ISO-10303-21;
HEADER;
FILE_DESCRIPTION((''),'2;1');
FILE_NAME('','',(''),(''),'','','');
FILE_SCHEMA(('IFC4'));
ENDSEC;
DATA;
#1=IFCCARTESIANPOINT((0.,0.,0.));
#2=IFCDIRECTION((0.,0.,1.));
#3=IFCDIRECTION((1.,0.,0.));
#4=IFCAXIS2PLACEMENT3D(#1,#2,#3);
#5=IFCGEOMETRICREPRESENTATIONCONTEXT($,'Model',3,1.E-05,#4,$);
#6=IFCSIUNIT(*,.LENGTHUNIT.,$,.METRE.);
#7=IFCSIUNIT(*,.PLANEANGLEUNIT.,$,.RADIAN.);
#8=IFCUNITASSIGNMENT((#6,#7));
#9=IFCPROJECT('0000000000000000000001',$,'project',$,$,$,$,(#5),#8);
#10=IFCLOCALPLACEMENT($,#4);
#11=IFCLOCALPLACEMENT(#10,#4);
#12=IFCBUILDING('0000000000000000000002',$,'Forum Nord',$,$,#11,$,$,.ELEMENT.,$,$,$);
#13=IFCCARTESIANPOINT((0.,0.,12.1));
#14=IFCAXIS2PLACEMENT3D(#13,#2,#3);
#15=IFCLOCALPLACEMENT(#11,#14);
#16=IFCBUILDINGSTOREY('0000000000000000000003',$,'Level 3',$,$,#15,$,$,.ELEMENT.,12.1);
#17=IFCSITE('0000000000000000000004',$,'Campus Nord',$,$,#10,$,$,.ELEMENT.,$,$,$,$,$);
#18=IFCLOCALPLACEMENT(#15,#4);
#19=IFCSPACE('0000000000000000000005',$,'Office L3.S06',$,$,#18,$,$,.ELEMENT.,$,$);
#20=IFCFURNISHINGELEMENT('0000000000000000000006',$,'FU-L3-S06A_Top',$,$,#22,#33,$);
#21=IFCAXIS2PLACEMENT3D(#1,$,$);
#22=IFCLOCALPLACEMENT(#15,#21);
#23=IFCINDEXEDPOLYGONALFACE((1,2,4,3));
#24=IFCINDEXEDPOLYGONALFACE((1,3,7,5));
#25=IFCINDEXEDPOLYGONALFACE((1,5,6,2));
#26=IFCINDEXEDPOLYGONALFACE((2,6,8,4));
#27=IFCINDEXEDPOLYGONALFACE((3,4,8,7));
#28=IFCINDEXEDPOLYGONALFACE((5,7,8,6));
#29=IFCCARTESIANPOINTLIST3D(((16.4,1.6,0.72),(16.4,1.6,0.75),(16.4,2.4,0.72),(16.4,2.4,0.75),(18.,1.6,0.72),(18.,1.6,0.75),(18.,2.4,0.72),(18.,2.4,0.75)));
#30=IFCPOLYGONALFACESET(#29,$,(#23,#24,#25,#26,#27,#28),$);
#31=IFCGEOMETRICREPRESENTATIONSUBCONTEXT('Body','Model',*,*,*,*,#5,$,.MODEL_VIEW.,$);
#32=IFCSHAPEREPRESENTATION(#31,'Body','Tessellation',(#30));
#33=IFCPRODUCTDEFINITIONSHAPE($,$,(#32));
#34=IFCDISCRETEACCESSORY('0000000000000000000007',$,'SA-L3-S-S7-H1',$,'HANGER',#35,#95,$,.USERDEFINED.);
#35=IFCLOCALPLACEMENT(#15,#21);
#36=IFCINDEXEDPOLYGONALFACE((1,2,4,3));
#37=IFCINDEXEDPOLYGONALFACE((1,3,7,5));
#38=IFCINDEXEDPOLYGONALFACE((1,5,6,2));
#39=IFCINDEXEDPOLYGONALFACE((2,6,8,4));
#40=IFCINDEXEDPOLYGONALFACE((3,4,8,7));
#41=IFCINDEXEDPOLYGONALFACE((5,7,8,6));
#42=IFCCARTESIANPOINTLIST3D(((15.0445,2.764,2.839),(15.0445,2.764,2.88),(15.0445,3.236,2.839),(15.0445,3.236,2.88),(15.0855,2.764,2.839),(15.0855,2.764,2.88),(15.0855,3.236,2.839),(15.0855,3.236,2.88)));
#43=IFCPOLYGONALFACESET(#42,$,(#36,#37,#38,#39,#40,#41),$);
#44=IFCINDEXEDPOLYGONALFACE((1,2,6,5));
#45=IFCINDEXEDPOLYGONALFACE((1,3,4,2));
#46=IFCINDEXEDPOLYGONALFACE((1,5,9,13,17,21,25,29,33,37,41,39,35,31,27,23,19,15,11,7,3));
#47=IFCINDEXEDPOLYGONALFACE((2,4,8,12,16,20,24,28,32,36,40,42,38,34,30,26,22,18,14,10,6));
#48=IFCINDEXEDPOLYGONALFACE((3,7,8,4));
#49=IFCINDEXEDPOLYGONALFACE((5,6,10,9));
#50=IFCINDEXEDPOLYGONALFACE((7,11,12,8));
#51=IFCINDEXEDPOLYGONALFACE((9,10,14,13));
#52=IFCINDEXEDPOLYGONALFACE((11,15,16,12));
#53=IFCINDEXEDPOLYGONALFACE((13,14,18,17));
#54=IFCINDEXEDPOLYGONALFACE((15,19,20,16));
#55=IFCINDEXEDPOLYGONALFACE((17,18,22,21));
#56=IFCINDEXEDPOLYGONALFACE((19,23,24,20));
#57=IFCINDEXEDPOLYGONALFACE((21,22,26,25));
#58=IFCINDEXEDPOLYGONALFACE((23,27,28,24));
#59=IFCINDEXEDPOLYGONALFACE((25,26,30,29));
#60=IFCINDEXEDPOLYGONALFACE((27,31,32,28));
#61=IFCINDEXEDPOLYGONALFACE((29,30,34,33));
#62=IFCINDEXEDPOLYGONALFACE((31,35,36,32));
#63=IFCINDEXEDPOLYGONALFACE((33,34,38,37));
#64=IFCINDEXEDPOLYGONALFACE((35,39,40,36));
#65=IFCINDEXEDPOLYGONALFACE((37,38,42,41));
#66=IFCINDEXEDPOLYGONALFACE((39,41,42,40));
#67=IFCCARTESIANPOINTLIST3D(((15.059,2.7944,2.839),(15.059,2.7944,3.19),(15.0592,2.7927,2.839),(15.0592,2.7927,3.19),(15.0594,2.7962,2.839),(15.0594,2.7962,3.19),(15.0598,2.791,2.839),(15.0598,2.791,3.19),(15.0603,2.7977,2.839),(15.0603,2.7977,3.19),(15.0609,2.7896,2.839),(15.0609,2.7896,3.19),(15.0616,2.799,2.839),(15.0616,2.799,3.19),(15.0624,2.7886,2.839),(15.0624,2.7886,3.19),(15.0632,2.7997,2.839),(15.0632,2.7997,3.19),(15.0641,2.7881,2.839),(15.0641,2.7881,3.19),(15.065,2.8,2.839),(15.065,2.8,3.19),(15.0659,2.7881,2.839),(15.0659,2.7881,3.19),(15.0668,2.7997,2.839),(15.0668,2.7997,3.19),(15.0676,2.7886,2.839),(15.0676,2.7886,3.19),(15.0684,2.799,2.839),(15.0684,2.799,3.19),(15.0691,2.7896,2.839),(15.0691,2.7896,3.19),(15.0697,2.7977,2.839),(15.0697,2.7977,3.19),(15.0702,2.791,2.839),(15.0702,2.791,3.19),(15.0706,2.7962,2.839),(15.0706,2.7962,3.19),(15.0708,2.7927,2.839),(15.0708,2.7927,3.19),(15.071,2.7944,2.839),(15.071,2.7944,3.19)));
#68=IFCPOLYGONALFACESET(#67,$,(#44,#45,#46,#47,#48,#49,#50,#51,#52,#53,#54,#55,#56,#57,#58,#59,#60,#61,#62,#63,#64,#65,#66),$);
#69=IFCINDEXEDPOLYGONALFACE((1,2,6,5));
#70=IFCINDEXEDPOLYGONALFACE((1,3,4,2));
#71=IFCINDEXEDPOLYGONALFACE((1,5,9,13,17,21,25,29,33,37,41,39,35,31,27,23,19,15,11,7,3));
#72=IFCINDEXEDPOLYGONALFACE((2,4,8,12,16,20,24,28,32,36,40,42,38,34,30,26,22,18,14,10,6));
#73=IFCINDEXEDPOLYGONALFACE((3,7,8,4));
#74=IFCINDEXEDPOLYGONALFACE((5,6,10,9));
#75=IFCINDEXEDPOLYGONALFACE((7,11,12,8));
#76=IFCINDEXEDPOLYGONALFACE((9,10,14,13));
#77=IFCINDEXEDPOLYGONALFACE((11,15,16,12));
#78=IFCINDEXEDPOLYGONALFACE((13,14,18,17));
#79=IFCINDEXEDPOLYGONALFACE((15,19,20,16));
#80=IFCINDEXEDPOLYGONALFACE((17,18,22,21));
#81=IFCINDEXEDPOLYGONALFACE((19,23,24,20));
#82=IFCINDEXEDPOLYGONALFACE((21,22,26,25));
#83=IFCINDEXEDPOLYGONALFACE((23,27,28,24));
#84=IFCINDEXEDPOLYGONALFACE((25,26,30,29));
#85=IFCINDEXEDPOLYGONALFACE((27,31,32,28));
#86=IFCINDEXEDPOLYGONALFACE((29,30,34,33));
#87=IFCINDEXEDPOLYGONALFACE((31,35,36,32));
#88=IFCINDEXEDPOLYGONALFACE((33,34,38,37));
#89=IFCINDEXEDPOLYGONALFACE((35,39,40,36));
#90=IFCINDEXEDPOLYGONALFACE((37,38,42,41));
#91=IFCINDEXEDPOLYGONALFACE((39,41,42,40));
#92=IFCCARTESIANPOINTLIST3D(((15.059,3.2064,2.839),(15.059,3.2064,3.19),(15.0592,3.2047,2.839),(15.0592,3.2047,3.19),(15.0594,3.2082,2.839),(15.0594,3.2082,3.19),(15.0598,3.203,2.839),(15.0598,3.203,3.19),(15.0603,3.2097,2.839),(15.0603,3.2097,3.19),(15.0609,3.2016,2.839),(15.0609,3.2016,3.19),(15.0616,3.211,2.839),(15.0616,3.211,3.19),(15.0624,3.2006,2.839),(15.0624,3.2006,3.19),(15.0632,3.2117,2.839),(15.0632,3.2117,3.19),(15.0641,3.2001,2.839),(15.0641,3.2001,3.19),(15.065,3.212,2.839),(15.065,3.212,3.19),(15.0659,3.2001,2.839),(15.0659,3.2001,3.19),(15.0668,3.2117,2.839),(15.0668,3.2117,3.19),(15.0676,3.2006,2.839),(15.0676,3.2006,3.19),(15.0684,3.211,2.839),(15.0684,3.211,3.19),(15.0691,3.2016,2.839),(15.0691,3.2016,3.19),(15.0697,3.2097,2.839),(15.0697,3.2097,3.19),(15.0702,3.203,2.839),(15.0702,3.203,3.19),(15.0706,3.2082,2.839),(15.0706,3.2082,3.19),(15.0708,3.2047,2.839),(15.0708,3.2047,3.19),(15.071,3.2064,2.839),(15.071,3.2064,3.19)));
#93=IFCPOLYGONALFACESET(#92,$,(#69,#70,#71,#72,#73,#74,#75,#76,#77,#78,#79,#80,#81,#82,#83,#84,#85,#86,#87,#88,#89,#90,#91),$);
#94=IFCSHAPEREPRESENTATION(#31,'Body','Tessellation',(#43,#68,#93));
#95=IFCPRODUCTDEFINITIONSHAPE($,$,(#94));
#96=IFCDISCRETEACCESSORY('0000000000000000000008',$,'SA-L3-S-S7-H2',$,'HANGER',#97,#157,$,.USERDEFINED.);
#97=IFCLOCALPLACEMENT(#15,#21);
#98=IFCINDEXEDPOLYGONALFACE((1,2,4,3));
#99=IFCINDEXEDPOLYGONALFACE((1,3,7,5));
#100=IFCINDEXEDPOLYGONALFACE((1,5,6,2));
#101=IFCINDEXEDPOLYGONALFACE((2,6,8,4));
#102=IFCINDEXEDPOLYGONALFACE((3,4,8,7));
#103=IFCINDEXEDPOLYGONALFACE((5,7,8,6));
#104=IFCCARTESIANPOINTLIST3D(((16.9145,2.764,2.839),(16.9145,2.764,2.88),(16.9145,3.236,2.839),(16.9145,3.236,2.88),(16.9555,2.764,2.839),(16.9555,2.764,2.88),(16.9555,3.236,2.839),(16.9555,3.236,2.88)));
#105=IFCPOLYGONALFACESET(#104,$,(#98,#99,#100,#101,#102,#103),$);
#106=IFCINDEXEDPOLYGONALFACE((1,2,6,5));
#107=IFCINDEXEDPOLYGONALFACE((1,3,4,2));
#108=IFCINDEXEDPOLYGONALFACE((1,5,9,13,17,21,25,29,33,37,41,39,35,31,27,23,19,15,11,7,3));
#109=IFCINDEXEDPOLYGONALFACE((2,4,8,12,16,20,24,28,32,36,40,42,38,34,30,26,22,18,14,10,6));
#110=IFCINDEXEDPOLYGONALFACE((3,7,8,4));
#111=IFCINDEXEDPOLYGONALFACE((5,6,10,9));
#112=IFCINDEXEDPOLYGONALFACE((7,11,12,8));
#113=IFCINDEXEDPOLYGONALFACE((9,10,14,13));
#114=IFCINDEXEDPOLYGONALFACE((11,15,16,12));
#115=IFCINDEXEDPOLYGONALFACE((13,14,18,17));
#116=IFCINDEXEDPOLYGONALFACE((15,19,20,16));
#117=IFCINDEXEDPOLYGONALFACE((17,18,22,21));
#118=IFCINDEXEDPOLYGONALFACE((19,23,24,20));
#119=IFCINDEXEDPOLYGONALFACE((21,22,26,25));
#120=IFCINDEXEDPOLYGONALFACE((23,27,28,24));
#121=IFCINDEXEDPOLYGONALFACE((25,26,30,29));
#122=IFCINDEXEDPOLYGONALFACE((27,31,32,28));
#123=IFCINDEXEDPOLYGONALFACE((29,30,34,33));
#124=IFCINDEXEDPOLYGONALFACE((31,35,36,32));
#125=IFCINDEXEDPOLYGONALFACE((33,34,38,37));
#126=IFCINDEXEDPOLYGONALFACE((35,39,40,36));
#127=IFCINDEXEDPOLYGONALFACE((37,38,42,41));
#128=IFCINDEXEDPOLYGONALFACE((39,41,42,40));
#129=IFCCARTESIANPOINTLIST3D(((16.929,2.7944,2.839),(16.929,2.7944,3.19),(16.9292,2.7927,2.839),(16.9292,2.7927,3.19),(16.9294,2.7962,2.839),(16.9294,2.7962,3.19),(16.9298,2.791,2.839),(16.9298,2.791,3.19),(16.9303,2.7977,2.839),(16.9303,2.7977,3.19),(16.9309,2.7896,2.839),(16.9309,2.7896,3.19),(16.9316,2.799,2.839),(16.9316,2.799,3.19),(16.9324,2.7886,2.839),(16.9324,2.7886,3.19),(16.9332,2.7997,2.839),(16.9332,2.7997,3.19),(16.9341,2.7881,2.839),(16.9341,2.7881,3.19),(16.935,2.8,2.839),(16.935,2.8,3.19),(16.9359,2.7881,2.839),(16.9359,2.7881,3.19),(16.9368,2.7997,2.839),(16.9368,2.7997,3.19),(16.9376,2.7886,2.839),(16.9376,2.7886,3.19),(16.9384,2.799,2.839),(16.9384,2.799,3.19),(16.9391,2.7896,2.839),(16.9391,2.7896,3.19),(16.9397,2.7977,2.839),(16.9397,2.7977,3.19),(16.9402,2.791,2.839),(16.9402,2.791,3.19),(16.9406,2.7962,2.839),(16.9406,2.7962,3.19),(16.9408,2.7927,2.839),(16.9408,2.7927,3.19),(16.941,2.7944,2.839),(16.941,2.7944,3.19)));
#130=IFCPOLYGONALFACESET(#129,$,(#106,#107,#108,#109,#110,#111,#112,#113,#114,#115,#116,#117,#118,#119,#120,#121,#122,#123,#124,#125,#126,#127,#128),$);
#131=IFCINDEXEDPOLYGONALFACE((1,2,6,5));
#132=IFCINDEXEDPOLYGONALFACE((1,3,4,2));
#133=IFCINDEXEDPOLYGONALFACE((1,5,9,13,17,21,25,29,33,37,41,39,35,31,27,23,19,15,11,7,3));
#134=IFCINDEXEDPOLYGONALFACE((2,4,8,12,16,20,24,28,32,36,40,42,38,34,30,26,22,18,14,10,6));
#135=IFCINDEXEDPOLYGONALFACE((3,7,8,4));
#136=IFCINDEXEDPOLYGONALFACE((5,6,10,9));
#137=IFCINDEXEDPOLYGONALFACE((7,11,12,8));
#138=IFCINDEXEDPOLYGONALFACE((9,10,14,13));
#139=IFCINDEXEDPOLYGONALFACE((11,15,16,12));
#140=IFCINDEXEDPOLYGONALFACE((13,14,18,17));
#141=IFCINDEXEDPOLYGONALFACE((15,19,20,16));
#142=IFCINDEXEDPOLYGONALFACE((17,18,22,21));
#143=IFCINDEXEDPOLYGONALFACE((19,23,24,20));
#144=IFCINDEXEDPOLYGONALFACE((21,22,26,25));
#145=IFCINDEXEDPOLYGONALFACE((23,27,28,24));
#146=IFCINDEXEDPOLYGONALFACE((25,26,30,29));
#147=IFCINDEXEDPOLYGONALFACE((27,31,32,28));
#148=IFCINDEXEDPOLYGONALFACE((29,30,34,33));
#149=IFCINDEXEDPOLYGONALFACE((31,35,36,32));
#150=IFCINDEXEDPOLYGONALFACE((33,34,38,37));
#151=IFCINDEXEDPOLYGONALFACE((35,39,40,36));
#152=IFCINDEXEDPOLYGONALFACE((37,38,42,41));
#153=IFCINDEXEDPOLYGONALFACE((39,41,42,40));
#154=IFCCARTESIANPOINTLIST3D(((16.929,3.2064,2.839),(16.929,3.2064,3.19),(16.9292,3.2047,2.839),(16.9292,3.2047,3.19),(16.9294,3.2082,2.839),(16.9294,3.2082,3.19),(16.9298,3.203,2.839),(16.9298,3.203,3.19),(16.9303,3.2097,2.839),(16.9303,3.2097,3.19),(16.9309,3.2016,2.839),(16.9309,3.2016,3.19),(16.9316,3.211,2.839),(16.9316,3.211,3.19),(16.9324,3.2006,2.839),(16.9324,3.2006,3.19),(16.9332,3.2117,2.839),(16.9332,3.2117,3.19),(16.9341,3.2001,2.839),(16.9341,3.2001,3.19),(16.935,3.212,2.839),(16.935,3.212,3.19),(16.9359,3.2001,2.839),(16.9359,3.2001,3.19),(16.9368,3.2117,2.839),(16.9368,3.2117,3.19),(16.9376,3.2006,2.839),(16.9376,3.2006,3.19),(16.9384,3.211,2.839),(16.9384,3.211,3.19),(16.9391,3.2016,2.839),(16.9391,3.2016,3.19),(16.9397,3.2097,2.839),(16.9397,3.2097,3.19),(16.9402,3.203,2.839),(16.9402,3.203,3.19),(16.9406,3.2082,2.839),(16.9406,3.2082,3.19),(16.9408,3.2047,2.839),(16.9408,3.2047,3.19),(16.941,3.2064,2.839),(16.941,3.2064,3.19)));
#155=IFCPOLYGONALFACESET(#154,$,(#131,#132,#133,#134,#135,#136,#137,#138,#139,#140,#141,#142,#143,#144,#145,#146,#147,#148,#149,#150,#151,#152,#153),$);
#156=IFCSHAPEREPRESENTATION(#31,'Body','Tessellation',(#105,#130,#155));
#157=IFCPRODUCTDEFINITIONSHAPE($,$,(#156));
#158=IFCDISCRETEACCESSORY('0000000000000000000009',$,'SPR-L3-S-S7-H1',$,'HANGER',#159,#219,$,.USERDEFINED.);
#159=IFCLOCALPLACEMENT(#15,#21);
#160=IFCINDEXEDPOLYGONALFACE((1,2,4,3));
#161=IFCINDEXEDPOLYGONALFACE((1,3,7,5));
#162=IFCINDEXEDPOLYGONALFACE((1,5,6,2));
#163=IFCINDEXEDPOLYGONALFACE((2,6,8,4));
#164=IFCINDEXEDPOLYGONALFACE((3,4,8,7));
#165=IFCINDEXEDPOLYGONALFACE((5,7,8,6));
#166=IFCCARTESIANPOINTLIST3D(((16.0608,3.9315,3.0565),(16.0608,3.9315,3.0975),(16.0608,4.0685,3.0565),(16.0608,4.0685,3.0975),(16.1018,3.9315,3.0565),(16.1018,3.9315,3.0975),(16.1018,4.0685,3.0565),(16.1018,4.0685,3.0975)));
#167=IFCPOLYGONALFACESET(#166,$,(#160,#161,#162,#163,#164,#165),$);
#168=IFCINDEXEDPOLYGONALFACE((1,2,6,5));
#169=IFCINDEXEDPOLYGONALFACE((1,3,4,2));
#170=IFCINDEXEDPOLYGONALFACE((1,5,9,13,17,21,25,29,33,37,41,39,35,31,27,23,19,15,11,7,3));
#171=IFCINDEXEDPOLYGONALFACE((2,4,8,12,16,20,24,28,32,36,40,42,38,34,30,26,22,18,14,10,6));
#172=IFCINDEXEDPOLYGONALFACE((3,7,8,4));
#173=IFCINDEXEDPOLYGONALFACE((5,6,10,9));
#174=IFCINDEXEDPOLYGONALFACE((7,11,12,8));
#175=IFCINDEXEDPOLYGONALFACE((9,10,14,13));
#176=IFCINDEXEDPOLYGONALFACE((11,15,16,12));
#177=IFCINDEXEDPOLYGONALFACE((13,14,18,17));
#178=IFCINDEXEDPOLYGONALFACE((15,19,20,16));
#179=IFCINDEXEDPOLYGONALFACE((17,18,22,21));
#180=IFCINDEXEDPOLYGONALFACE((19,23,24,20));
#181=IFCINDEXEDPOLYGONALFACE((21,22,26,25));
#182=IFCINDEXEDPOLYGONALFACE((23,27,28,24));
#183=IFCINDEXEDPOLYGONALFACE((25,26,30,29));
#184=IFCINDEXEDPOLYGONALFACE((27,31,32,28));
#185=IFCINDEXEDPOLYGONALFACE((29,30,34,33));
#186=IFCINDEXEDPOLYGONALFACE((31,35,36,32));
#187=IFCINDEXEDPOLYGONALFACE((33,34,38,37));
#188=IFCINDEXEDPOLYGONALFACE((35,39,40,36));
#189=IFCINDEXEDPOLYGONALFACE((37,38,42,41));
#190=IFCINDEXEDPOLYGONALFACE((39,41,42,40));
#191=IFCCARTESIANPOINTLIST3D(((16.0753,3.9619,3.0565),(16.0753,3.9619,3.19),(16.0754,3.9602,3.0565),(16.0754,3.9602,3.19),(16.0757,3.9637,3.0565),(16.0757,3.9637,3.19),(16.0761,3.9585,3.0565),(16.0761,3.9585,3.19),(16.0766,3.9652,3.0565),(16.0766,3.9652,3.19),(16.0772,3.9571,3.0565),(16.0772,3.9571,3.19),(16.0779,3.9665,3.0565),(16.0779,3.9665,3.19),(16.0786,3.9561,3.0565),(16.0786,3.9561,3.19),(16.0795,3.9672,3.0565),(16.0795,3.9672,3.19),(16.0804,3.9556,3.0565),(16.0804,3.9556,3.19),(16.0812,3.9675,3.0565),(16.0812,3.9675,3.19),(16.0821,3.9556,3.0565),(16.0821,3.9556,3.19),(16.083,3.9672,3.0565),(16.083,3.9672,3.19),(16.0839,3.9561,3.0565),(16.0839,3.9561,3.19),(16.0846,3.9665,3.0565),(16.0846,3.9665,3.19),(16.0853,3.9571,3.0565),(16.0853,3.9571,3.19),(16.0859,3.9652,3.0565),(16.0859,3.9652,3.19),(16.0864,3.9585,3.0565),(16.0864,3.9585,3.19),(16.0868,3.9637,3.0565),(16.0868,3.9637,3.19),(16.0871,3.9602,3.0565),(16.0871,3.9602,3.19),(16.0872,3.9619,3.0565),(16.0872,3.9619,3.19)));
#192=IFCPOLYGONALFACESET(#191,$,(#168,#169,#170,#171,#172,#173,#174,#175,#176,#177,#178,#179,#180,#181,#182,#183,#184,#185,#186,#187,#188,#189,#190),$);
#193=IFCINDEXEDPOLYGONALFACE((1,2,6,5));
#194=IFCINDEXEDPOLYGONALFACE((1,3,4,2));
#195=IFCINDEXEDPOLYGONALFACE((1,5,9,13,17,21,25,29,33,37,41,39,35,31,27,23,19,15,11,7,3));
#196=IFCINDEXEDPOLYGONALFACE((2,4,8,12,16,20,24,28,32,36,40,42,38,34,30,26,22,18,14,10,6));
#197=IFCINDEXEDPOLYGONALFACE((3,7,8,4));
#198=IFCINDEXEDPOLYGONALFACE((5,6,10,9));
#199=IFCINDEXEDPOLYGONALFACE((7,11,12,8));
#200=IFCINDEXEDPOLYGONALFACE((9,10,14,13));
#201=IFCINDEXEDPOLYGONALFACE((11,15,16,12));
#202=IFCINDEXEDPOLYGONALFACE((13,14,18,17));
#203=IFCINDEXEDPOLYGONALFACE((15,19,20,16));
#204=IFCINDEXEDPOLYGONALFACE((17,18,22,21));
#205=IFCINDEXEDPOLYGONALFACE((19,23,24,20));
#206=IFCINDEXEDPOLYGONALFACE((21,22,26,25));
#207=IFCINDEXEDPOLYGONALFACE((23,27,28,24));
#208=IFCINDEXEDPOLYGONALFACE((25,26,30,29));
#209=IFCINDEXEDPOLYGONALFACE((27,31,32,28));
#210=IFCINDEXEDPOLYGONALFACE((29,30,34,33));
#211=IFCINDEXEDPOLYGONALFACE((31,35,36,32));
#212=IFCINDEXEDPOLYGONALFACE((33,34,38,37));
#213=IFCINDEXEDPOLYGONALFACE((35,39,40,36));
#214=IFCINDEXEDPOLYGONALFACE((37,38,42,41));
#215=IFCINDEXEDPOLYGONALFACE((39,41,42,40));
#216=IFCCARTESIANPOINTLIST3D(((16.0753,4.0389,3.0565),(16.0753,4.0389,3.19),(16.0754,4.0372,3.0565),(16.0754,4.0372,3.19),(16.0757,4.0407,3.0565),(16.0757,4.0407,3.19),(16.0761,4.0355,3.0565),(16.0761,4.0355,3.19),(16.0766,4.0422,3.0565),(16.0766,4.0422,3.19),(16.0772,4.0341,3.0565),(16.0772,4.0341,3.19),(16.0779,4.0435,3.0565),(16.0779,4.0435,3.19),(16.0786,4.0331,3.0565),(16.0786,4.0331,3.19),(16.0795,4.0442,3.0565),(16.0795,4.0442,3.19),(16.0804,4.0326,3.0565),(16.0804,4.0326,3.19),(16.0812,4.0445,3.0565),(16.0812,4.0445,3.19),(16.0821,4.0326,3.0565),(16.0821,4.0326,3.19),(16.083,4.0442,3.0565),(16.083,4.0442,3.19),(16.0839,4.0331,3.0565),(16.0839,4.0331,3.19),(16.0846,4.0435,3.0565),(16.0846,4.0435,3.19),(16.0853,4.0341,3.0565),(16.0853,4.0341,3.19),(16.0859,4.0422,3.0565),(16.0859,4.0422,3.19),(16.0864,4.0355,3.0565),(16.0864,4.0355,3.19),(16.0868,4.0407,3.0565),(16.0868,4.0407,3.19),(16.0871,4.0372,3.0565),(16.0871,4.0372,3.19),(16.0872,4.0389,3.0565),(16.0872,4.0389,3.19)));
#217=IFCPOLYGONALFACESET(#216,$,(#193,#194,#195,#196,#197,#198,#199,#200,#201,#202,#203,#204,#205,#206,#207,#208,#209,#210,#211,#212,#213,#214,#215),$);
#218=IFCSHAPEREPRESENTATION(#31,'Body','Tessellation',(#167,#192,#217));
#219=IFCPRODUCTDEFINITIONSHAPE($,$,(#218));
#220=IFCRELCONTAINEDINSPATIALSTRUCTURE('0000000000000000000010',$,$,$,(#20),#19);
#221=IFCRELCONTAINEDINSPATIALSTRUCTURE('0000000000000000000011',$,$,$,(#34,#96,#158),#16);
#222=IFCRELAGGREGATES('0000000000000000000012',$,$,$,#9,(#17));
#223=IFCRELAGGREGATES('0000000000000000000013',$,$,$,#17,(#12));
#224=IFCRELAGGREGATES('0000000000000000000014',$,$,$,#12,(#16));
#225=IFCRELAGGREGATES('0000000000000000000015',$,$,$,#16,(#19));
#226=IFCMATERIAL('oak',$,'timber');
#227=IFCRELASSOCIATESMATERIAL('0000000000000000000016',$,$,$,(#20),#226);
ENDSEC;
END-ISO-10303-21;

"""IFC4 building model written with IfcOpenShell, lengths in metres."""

from ifc_helpers import new_model, si_unit, frame, frame_2d, origin_with_axes, origin_2d_with_axis, place, context, subcontext, project, spatial, rectangle, circle, extrude, material, element, save


model = new_model("IFC4")

# Units and contexts
model_context = context("Model", 3, precision=1e-05, world=origin_with_axes())
body_context = subcontext(model_context, "Body", "Model", "MODEL_VIEW")
ifc_project = project(units=[si_unit("LENGTHUNIT", "METRE"), si_unit("PLANEANGLEUNIT", "RADIAN")], contexts=[model_context])

# Site, building, storey
site_placement = place(None, origin_with_axes())
site = spatial("IfcSite", under=ifc_project, at=site_placement, Name="Campus Nord", CompositionType="ELEMENT")
building_placement = place(site_placement, origin_with_axes())
building = spatial("IfcBuilding", under=site, at=building_placement, Name="Forum Nord", CompositionType="ELEMENT")
storey_placement = place(building_placement, frame((0.0, 0.0, 12.1), z_axis=(0.0, 0.0, 1.0), x_axis=(1.0, 0.0, 0.0)))
storey = spatial("IfcBuildingStorey", under=building, at=storey_placement, Name="Level 3", CompositionType="ELEMENT", Elevation=12.1)

# Shared definitions
space_1_placement = place(storey_placement, origin_with_axes())
space_1 = spatial("IfcSpace", under=storey, at=space_1_placement, Name="Office L3.S06", CompositionType="ELEMENT")

# Furnishing element
ifc_material_1 = material(Name="oak", Category="timber")
furnishing_1_placement = place(storey_placement, frame((16.4, 1.0, 0.0), z_axis=(0.0, 0.0, 1.0), x_axis=(1.0, 0.0, 0.0)))
element("IfcFurnishingElement", 1, at=furnishing_1_placement, inside=space_1, material=ifc_material_1, Name="FU-L3-S06A_Top", context=body_context, shape_type="SweptSolid", body=[
    extrude(rectangle(XDim=1.6, YDim=0.8, at=frame_2d((0.8, 1.0), x_axis=(1.0, 0.0))), frame((0.0, 0.0, 0.72), z_axis=(0.0, 0.0, 1.0), x_axis=(1.0, 0.0, 0.0)), (0.0, 0.0, 1.0), 0.03),
])

# Discrete accessories
for number, where, z_axis, x_axis, name in (
    (2, (15.065, 3.0, 2.88), (0.0, 0.0, 1.0), (0.0, 1.0, 0.0), "SA-L3-S-S7-H1"),
    (3, (16.935, 3.0, 2.88), (0.0, 0.0, 1.0), (0.0, 1.0, 0.0), "SA-L3-S-S7-H2"),
):
    element("IfcDiscreteAccessory", number, at=place(storey_placement, frame(where, z_axis=z_axis, x_axis=x_axis)), inside=storey, Name=name, ObjectType="HANGER", PredefinedType="USERDEFINED", context=body_context, shape_type="SweptSolid", body=[
        extrude(rectangle(XDim=0.472, YDim=0.041, at=origin_2d_with_axis()), frame((0.0, 0.0, -0.041), z_axis=(0.0, 0.0, 1.0), x_axis=(1.0, 0.0, 0.0)), (0.0, 0.0, 1.0), 0.041),
        extrude(circle(Radius=0.006, at=frame_2d((-0.206, 0.0), x_axis=(1.0, 0.0))), frame((0.0, 0.0, -0.041), z_axis=(0.0, 0.0, 1.0), x_axis=(1.0, 0.0, 0.0)), (0.0, 0.0, 1.0), 0.351),
        extrude(circle(Radius=0.006, at=frame_2d((0.206, 0.0), x_axis=(1.0, 0.0))), frame((0.0, 0.0, -0.041), z_axis=(0.0, 0.0, 1.0), x_axis=(1.0, 0.0, 0.0)), (0.0, 0.0, 1.0), 0.351),
    ])
discrete_accessory_placement = place(storey_placement, frame((16.0813, 4.0, 3.0975), z_axis=(0.0, 0.0, 1.0), x_axis=(0.0, 1.0, 0.0)))
element("IfcDiscreteAccessory", 4, at=discrete_accessory_placement, inside=storey, Name="SPR-L3-S-S7-H1", ObjectType="HANGER", PredefinedType="USERDEFINED", context=body_context, shape_type="SweptSolid", body=[
    extrude(rectangle(XDim=0.137, YDim=0.041, at=origin_2d_with_axis()), frame((0.0, 0.0, -0.041), z_axis=(0.0, 0.0, 1.0), x_axis=(1.0, 0.0, 0.0)), (0.0, 0.0, 1.0), 0.041),
    extrude(circle(Radius=0.006, at=frame_2d((-0.0385, 0.0), x_axis=(1.0, 0.0))), frame((0.0, 0.0, -0.041), z_axis=(0.0, 0.0, 1.0), x_axis=(1.0, 0.0, 0.0)), (0.0, 0.0, 1.0), 0.1335),
    extrude(circle(Radius=0.006, at=frame_2d((0.0385, 0.0), x_axis=(1.0, 0.0))), frame((0.0, 0.0, -0.041), z_axis=(0.0, 0.0, 1.0), x_axis=(1.0, 0.0, 0.0)), (0.0, 0.0, 1.0), 0.1335),
])

save(model, "model.ifc")
